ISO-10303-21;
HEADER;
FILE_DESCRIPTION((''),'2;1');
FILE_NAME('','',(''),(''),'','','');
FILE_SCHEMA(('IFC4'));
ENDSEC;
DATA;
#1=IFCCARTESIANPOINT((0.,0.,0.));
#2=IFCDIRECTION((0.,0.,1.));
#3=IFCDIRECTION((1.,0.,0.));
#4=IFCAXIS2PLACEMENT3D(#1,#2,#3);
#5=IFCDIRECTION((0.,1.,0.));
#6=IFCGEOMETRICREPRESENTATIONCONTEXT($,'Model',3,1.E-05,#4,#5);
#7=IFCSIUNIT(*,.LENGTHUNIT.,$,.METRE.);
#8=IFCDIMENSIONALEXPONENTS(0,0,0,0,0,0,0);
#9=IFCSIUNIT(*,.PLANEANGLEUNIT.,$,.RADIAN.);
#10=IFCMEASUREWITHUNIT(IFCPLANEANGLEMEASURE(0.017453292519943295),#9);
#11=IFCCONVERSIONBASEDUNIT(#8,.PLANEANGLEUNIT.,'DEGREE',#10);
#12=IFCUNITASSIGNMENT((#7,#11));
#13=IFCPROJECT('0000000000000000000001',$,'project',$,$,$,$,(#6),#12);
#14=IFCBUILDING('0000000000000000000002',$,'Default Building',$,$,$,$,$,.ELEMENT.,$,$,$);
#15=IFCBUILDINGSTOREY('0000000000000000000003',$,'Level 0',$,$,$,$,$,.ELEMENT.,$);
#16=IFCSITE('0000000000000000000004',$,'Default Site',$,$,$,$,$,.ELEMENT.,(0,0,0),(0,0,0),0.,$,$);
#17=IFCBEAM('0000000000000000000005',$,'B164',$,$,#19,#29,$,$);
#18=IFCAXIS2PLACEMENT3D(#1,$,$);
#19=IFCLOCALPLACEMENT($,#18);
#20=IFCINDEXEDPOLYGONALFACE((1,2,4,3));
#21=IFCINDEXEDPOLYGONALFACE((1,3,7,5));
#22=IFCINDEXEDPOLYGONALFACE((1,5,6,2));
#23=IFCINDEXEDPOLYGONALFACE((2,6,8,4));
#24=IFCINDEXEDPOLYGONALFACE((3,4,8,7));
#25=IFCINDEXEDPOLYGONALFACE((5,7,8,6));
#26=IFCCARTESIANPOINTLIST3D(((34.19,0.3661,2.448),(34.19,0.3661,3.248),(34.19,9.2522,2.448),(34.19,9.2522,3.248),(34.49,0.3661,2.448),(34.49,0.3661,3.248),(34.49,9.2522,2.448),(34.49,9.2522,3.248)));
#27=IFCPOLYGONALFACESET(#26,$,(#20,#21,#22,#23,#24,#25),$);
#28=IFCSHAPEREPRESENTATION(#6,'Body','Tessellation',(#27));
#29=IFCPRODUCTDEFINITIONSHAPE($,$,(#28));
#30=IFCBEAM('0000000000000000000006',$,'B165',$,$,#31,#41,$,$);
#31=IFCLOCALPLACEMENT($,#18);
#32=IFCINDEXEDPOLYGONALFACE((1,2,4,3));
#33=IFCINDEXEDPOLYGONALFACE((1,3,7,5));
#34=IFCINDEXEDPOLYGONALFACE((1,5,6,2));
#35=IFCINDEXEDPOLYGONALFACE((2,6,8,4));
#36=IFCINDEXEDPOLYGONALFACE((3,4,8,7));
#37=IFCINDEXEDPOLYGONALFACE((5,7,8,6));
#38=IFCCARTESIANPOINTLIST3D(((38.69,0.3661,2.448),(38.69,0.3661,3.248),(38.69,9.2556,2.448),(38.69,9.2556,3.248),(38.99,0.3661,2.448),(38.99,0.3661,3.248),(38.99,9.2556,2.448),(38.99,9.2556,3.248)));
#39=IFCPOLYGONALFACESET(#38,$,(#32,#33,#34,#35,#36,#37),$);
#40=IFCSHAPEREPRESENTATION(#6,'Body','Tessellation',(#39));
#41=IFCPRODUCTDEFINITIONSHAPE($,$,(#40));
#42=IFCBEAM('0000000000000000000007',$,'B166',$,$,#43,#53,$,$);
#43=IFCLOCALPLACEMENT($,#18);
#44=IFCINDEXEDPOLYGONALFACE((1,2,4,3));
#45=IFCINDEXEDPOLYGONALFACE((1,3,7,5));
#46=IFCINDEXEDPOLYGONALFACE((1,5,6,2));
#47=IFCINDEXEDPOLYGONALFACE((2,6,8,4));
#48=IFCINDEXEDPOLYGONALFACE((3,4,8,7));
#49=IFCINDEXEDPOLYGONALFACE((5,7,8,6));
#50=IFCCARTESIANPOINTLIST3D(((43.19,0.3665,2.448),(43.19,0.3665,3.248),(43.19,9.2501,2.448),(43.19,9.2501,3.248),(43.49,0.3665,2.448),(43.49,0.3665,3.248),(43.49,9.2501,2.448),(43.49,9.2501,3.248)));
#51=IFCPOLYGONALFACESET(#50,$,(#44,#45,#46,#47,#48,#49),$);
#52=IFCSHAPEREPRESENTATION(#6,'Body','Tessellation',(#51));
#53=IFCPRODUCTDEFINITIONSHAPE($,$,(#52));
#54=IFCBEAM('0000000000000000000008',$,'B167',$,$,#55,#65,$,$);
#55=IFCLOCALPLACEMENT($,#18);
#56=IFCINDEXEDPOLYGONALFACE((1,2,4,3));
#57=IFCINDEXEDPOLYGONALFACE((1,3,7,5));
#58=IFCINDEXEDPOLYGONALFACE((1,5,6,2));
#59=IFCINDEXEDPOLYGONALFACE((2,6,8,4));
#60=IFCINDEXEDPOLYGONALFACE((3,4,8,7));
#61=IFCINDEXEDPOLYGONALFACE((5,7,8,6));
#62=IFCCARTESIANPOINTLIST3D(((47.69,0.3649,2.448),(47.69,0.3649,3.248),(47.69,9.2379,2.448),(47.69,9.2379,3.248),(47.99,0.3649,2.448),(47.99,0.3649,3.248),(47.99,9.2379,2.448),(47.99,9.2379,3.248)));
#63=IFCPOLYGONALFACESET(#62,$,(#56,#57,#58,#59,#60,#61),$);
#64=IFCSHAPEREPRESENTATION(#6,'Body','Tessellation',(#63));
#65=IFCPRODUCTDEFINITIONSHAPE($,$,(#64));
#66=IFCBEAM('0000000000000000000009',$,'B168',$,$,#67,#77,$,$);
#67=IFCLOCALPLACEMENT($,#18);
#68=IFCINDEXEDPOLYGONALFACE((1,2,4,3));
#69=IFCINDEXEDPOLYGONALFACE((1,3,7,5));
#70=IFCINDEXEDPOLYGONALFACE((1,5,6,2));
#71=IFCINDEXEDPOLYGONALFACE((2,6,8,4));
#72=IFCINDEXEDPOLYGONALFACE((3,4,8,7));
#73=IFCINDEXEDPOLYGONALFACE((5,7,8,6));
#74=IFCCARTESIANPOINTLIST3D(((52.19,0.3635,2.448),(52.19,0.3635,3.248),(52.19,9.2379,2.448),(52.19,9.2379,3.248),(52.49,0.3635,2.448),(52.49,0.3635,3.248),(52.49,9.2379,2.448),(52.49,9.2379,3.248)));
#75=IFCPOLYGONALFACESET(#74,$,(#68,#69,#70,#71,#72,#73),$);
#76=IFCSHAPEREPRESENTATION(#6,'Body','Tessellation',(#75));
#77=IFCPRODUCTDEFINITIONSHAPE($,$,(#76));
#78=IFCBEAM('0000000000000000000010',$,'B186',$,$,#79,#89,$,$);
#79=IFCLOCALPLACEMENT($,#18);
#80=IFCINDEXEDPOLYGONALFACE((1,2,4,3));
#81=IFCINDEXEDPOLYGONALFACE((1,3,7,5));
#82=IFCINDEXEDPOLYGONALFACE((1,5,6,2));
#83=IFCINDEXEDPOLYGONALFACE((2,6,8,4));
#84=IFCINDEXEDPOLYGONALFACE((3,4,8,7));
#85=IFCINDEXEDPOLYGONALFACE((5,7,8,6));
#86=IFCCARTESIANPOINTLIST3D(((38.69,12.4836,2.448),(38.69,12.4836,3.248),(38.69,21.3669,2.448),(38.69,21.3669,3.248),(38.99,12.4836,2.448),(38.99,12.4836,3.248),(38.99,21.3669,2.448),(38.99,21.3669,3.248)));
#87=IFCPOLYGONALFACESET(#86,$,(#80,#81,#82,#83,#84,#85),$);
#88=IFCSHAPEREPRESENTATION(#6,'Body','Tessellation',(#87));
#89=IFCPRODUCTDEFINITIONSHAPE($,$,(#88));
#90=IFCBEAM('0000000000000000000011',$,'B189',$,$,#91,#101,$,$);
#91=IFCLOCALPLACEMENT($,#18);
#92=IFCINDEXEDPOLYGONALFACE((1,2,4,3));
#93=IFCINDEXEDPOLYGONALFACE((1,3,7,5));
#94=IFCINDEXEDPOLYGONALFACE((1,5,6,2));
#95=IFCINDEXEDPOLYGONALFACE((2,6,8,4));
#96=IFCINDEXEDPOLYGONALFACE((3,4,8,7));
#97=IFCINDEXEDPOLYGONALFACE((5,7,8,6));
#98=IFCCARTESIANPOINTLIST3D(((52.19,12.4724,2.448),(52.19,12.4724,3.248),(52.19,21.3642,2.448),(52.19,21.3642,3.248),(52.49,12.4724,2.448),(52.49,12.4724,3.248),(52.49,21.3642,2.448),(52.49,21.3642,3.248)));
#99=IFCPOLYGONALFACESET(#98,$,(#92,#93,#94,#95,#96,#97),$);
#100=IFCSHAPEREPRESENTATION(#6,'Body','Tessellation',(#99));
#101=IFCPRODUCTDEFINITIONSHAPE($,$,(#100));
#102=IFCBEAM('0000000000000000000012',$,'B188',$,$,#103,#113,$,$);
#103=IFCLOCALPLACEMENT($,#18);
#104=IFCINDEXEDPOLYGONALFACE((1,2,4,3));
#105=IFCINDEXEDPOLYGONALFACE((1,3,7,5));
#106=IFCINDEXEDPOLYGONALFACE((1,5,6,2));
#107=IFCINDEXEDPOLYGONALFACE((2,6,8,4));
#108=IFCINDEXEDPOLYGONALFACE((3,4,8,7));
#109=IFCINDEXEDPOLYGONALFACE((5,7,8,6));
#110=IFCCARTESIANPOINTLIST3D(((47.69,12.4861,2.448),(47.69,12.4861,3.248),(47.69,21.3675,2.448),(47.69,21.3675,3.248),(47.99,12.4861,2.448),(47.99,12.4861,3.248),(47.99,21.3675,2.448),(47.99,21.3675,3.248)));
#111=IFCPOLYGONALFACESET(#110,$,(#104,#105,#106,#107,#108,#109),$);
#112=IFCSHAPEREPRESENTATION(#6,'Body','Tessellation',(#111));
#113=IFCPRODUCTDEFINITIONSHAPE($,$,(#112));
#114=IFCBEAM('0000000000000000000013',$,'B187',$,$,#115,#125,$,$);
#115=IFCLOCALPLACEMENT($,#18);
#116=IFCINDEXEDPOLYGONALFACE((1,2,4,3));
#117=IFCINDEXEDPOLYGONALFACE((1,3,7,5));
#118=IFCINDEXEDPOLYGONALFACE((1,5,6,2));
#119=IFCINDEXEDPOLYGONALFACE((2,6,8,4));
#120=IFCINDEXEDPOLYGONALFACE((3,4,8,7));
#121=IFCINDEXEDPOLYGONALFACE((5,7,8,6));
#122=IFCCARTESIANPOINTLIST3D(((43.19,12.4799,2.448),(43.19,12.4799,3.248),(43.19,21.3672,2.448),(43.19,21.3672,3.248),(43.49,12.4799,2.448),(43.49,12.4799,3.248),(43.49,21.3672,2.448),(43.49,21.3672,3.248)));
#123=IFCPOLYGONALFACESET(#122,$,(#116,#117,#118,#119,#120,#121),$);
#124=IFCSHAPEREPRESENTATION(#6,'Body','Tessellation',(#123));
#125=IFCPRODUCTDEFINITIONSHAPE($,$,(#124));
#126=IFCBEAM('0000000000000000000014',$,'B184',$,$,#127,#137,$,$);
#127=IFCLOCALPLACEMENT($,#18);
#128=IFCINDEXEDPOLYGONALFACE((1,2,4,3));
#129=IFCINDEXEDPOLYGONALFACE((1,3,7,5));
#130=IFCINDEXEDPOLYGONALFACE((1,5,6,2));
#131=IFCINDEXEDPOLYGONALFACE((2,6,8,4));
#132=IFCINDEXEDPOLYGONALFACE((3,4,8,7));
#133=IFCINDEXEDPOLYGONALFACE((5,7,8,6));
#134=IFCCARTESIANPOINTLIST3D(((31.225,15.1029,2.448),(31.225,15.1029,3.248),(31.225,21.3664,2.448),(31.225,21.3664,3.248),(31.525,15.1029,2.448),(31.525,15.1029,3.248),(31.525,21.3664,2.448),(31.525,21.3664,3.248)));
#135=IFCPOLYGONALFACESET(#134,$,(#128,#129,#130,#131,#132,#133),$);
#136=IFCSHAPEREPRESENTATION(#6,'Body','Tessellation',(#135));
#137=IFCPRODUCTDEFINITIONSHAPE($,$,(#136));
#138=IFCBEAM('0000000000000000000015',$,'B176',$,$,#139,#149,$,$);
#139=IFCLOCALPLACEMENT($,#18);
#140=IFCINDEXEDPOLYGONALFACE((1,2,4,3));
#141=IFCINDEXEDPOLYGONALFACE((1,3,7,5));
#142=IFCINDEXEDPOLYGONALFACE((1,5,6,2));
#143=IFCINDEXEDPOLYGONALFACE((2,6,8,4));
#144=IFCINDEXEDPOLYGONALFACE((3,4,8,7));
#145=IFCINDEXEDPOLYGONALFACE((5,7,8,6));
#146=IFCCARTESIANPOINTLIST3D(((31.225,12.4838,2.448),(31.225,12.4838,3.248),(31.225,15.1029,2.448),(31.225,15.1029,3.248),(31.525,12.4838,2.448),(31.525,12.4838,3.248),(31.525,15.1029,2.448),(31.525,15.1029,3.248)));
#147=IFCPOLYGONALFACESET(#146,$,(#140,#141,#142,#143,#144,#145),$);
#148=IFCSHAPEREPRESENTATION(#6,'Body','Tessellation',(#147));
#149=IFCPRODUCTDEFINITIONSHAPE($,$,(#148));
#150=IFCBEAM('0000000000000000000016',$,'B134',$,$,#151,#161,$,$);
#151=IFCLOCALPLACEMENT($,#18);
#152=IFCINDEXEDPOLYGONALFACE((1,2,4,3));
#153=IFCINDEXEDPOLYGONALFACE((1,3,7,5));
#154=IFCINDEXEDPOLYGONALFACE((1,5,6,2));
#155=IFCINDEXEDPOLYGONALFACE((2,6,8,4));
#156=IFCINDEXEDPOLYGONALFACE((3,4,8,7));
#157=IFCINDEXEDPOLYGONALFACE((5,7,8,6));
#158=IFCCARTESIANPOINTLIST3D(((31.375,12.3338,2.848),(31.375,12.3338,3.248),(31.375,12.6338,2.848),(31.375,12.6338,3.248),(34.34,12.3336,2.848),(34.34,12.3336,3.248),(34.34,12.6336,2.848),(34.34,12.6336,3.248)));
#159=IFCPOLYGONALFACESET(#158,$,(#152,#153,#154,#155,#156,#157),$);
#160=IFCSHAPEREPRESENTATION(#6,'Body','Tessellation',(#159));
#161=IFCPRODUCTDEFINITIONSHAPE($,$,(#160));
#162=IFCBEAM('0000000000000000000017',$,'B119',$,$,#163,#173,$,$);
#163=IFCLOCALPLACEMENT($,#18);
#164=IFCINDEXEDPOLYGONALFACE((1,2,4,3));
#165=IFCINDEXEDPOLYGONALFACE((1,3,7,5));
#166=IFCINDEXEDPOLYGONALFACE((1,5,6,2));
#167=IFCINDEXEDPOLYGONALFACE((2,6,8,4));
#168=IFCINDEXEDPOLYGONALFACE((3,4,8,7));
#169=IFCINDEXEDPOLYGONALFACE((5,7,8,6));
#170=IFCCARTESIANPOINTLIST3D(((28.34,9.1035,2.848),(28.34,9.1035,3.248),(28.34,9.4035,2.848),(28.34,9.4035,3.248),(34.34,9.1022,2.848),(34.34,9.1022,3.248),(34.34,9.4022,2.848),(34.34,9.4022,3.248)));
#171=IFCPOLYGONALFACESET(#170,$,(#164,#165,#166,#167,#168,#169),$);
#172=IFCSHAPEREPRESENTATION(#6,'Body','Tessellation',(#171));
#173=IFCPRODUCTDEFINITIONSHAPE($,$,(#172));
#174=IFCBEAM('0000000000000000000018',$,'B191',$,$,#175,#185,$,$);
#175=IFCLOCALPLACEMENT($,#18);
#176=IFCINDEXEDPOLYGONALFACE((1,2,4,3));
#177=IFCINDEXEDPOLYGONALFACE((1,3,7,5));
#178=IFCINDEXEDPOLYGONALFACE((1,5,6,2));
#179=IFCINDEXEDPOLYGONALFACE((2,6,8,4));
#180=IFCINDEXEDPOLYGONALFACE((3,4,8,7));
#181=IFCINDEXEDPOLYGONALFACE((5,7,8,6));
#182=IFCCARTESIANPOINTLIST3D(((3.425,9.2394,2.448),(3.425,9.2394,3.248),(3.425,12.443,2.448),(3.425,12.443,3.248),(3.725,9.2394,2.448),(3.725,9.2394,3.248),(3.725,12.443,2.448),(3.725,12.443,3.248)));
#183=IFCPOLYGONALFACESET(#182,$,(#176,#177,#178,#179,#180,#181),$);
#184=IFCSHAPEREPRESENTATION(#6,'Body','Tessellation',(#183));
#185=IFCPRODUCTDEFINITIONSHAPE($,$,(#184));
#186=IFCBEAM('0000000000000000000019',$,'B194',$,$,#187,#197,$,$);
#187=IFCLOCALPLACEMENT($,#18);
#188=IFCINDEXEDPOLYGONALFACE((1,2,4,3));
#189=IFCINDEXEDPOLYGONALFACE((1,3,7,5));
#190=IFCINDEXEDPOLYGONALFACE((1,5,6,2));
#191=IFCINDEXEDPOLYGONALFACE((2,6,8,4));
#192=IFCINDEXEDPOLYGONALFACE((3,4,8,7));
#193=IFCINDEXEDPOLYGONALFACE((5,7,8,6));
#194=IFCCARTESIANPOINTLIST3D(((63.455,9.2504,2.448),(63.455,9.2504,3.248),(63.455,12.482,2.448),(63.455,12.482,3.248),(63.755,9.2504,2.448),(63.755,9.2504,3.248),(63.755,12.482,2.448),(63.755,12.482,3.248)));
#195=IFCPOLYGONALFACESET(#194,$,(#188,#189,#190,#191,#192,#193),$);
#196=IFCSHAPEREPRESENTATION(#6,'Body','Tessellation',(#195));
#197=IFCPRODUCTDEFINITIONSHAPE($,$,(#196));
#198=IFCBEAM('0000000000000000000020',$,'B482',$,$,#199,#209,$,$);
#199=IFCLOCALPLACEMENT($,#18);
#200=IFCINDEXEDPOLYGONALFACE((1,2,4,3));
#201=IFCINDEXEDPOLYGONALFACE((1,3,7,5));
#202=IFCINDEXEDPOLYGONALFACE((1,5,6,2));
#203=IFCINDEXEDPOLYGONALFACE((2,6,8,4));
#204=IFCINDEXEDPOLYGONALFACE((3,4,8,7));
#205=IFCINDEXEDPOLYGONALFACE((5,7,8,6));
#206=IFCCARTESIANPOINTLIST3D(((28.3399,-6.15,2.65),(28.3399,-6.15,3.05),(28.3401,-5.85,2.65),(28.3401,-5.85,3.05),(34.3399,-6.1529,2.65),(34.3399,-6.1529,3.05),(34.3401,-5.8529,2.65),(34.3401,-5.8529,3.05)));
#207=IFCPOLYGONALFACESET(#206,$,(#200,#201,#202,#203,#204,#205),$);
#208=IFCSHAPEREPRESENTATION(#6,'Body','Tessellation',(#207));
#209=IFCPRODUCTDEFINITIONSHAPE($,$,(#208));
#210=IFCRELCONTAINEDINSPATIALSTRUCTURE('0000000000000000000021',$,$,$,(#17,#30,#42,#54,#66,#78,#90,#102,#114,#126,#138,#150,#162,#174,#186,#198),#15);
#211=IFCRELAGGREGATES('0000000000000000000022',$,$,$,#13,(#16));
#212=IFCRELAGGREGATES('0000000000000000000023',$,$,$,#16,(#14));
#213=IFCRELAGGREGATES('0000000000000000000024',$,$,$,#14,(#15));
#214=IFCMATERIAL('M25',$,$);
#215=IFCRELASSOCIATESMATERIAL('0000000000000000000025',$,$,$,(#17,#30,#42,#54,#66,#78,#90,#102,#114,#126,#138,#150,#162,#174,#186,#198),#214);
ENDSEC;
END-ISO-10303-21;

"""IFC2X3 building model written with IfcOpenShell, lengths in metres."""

from ifc_helpers import new_model, entity, si_unit, converted_unit, direction, frame, frame_2d, origin_with_axes, place, context, project, spatial, rectangle, extrude, material, element, save


model = new_model("IFC2X3")

# Units and contexts
model_context = context("Model", 3, precision=1e-05, world=origin_with_axes(), true_north=direction((0.0, 1.0, 0.0)))
ifc_project = project(units=[si_unit("LENGTHUNIT", "METRE"), converted_unit("PLANEANGLEUNIT", "DEGREE", entity("IfcPlaneAngleMeasure", 0.017453292519943295), si_unit("PLANEANGLEUNIT", "RADIAN"), dimensions=[0, 0, 0, 0, 0, 0, 0])], contexts=[model_context])

# Site, building, storey
site = spatial("IfcSite", under=ifc_project, Name="Default Site", CompositionType="ELEMENT", RefLatitude=(0, 0, 0), RefLongitude=(0, 0, 0), RefElevation=0.0)
building = spatial("IfcBuilding", under=site, Name="Default Building", CompositionType="ELEMENT")
storey = spatial("IfcBuildingStorey", under=building, Name="Level 0", CompositionType="ELEMENT")

# Beams
ifc_material = material(Name="M25")
placement = place(None, origin_with_axes())
element("IfcBeam", 1, at=placement, inside=storey, material=ifc_material, Name="B164", context=model_context, shape_type="SweptSolid", body=[
    extrude(rectangle(XDim=0.3, YDim=0.8, at=frame_2d((0.0, 0.0), x_axis=(0.0, 1.0, 0.0))), frame((34.34, 0.3661, 2.848), z_axis=(0.0, 1.0, 0.0), x_axis=(0.0, 0.0, -1.0)), (0.0, 0.0, 1.0), 8.8861),
])
element("IfcBeam", 2, at=placement, inside=storey, material=ifc_material, Name="B165", context=model_context, shape_type="SweptSolid", body=[
    extrude(rectangle(XDim=0.3, YDim=0.8, at=frame_2d((0.0, 0.0), x_axis=(0.0, 1.0, 0.0))), frame((38.84, 0.3661, 2.848), z_axis=(0.0, 1.0, 0.0), x_axis=(0.0, 0.0, -1.0)), (0.0, 0.0, 1.0), 8.8895),
])
element("IfcBeam", 3, at=placement, inside=storey, material=ifc_material, Name="B166", context=model_context, shape_type="SweptSolid", body=[
    extrude(rectangle(XDim=0.3, YDim=0.8, at=frame_2d((0.0, 0.0), x_axis=(0.0, 1.0, 0.0))), frame((43.34, 0.3665, 2.848), z_axis=(0.0, 1.0, 0.0), x_axis=(0.0, 0.0, -1.0)), (0.0, 0.0, 1.0), 8.8836),
])
element("IfcBeam", 4, at=placement, inside=storey, material=ifc_material, Name="B167", context=model_context, shape_type="SweptSolid", body=[
    extrude(rectangle(XDim=0.3, YDim=0.8, at=frame_2d((0.0, 0.0), x_axis=(0.0, 1.0, 0.0))), frame((47.84, 0.3649, 2.848), z_axis=(0.0, 1.0, 0.0), x_axis=(0.0, 0.0, -1.0)), (0.0, 0.0, 1.0), 8.873),
])
element("IfcBeam", 5, at=placement, inside=storey, material=ifc_material, Name="B168", context=model_context, shape_type="SweptSolid", body=[
    extrude(rectangle(XDim=0.3, YDim=0.8, at=frame_2d((0.0, 0.0), x_axis=(0.0, 1.0, 0.0))), frame((52.34, 0.3635, 2.848), z_axis=(0.0, 1.0, 0.0), x_axis=(0.0, 0.0, -1.0)), (0.0, 0.0, 1.0), 8.8744),
])
element("IfcBeam", 6, at=placement, inside=storey, material=ifc_material, Name="B186", context=model_context, shape_type="SweptSolid", body=[
    extrude(rectangle(XDim=0.3, YDim=0.8, at=frame_2d((0.0, 0.0), x_axis=(0.0, 1.0, 0.0))), frame((38.84, 21.3669, 2.848), z_axis=(0.0, -1.0, 0.0), x_axis=(0.0, 0.0, -1.0)), (0.0, 0.0, 1.0), 8.8833),
])
element("IfcBeam", 7, at=placement, inside=storey, material=ifc_material, Name="B189", context=model_context, shape_type="SweptSolid", body=[
    extrude(rectangle(XDim=0.3, YDim=0.8, at=frame_2d((0.0, 0.0), x_axis=(0.0, 1.0, 0.0))), frame((52.34, 12.4724, 2.848), z_axis=(0.0, 1.0, 0.0), x_axis=(0.0, 0.0, -1.0)), (0.0, 0.0, 1.0), 8.8918),
])
element("IfcBeam", 8, at=placement, inside=storey, material=ifc_material, Name="B188", context=model_context, shape_type="SweptSolid", body=[
    extrude(rectangle(XDim=0.3, YDim=0.8, at=frame_2d((0.0, 0.0), x_axis=(0.0, 1.0, 0.0))), frame((47.84, 12.4861, 2.848), z_axis=(0.0, 1.0, 0.0), x_axis=(0.0, 0.0, -1.0)), (0.0, 0.0, 1.0), 8.8814),
])
element("IfcBeam", 9, at=placement, inside=storey, material=ifc_material, Name="B187", context=model_context, shape_type="SweptSolid", body=[
    extrude(rectangle(XDim=0.3, YDim=0.8, at=frame_2d((0.0, 0.0), x_axis=(0.0, 1.0, 0.0))), frame((43.34, 21.3672, 2.848), z_axis=(0.0, -1.0, 0.0), x_axis=(0.0, 0.0, -1.0)), (0.0, 0.0, 1.0), 8.8873),
])
element("IfcBeam", 10, at=placement, inside=storey, material=ifc_material, Name="B184", context=model_context, shape_type="SweptSolid", body=[
    extrude(rectangle(XDim=0.3, YDim=0.8, at=frame_2d((0.0, 0.0), x_axis=(0.0, 1.0, 0.0))), frame((31.375, 21.3664, 2.848), z_axis=(0.0, -1.0, 0.0), x_axis=(0.0, 0.0, -1.0)), (0.0, 0.0, 1.0), 6.2635),
])
element("IfcBeam", 11, at=placement, inside=storey, material=ifc_material, Name="B176", context=model_context, shape_type="SweptSolid", body=[
    extrude(rectangle(XDim=0.3, YDim=0.8, at=frame_2d((0.0, 0.0), x_axis=(0.0, 1.0, 0.0))), frame((31.375, 15.1029, 2.848), z_axis=(0.0, -1.0, 0.0), x_axis=(0.0, 0.0, -1.0)), (0.0, 0.0, 1.0), 2.6191),
])
element("IfcBeam", 12, at=placement, inside=storey, material=ifc_material, Name="B134", context=model_context, shape_type="SweptSolid", body=[
    extrude(rectangle(XDim=0.3, YDim=0.4, at=frame_2d((0.0, 0.0), x_axis=(0.0, 1.0, 0.0))), frame((31.375, 12.4838, 3.048), z_axis=(1.0, -0.000067, 0.0), x_axis=(0.0, 0.0, -1.0)), (0.0, 0.0, 1.0), 2.965),
])
element("IfcBeam", 13, at=placement, inside=storey, material=ifc_material, Name="B119", context=model_context, shape_type="SweptSolid", body=[
    extrude(rectangle(XDim=0.3, YDim=0.4, at=frame_2d((0.0, 0.0), x_axis=(0.0, 1.0, 0.0))), frame((28.34, 9.2535, 3.048), z_axis=(1.0, -0.000213, 0.0), x_axis=(0.0, 0.0, -1.0)), (0.0, 0.0, 1.0), 6.0),
])
element("IfcBeam", 14, at=placement, inside=storey, material=ifc_material, Name="B191", context=model_context, shape_type="SweptSolid", body=[
    extrude(rectangle(XDim=0.3, YDim=0.8, at=frame_2d((0.0, 0.0), x_axis=(0.0, 1.0, 0.0))), frame((3.575, 12.443, 2.848), z_axis=(0.0, -1.0, 0.0), x_axis=(0.0, 0.0, -1.0)), (0.0, 0.0, 1.0), 3.2036),
])
element("IfcBeam", 15, at=placement, inside=storey, material=ifc_material, Name="B194", context=model_context, shape_type="SweptSolid", body=[
    extrude(rectangle(XDim=0.3, YDim=0.8, at=frame_2d((0.0, 0.0), x_axis=(0.0, 1.0, 0.0))), frame((63.605, 12.482, 2.848), z_axis=(0.0, -1.0, 0.0), x_axis=(0.0, 0.0, -1.0)), (0.0, 0.0, 1.0), 3.2316),
])
element("IfcBeam", 16, at=placement, inside=storey, material=ifc_material, Name="B482", context=model_context, shape_type="SweptSolid", body=[
    extrude(rectangle(XDim=0.3, YDim=0.4, at=frame_2d((0.0, 0.0), x_axis=(0.0, 1.0, 0.0))), frame((28.34, -6.0, 2.85), z_axis=(1.0, -0.000487, 0.0), x_axis=(0.0, 0.0, -1.0)), (0.0, 0.0, 1.0), 6.0),
])

save(model, "model.ifc")
